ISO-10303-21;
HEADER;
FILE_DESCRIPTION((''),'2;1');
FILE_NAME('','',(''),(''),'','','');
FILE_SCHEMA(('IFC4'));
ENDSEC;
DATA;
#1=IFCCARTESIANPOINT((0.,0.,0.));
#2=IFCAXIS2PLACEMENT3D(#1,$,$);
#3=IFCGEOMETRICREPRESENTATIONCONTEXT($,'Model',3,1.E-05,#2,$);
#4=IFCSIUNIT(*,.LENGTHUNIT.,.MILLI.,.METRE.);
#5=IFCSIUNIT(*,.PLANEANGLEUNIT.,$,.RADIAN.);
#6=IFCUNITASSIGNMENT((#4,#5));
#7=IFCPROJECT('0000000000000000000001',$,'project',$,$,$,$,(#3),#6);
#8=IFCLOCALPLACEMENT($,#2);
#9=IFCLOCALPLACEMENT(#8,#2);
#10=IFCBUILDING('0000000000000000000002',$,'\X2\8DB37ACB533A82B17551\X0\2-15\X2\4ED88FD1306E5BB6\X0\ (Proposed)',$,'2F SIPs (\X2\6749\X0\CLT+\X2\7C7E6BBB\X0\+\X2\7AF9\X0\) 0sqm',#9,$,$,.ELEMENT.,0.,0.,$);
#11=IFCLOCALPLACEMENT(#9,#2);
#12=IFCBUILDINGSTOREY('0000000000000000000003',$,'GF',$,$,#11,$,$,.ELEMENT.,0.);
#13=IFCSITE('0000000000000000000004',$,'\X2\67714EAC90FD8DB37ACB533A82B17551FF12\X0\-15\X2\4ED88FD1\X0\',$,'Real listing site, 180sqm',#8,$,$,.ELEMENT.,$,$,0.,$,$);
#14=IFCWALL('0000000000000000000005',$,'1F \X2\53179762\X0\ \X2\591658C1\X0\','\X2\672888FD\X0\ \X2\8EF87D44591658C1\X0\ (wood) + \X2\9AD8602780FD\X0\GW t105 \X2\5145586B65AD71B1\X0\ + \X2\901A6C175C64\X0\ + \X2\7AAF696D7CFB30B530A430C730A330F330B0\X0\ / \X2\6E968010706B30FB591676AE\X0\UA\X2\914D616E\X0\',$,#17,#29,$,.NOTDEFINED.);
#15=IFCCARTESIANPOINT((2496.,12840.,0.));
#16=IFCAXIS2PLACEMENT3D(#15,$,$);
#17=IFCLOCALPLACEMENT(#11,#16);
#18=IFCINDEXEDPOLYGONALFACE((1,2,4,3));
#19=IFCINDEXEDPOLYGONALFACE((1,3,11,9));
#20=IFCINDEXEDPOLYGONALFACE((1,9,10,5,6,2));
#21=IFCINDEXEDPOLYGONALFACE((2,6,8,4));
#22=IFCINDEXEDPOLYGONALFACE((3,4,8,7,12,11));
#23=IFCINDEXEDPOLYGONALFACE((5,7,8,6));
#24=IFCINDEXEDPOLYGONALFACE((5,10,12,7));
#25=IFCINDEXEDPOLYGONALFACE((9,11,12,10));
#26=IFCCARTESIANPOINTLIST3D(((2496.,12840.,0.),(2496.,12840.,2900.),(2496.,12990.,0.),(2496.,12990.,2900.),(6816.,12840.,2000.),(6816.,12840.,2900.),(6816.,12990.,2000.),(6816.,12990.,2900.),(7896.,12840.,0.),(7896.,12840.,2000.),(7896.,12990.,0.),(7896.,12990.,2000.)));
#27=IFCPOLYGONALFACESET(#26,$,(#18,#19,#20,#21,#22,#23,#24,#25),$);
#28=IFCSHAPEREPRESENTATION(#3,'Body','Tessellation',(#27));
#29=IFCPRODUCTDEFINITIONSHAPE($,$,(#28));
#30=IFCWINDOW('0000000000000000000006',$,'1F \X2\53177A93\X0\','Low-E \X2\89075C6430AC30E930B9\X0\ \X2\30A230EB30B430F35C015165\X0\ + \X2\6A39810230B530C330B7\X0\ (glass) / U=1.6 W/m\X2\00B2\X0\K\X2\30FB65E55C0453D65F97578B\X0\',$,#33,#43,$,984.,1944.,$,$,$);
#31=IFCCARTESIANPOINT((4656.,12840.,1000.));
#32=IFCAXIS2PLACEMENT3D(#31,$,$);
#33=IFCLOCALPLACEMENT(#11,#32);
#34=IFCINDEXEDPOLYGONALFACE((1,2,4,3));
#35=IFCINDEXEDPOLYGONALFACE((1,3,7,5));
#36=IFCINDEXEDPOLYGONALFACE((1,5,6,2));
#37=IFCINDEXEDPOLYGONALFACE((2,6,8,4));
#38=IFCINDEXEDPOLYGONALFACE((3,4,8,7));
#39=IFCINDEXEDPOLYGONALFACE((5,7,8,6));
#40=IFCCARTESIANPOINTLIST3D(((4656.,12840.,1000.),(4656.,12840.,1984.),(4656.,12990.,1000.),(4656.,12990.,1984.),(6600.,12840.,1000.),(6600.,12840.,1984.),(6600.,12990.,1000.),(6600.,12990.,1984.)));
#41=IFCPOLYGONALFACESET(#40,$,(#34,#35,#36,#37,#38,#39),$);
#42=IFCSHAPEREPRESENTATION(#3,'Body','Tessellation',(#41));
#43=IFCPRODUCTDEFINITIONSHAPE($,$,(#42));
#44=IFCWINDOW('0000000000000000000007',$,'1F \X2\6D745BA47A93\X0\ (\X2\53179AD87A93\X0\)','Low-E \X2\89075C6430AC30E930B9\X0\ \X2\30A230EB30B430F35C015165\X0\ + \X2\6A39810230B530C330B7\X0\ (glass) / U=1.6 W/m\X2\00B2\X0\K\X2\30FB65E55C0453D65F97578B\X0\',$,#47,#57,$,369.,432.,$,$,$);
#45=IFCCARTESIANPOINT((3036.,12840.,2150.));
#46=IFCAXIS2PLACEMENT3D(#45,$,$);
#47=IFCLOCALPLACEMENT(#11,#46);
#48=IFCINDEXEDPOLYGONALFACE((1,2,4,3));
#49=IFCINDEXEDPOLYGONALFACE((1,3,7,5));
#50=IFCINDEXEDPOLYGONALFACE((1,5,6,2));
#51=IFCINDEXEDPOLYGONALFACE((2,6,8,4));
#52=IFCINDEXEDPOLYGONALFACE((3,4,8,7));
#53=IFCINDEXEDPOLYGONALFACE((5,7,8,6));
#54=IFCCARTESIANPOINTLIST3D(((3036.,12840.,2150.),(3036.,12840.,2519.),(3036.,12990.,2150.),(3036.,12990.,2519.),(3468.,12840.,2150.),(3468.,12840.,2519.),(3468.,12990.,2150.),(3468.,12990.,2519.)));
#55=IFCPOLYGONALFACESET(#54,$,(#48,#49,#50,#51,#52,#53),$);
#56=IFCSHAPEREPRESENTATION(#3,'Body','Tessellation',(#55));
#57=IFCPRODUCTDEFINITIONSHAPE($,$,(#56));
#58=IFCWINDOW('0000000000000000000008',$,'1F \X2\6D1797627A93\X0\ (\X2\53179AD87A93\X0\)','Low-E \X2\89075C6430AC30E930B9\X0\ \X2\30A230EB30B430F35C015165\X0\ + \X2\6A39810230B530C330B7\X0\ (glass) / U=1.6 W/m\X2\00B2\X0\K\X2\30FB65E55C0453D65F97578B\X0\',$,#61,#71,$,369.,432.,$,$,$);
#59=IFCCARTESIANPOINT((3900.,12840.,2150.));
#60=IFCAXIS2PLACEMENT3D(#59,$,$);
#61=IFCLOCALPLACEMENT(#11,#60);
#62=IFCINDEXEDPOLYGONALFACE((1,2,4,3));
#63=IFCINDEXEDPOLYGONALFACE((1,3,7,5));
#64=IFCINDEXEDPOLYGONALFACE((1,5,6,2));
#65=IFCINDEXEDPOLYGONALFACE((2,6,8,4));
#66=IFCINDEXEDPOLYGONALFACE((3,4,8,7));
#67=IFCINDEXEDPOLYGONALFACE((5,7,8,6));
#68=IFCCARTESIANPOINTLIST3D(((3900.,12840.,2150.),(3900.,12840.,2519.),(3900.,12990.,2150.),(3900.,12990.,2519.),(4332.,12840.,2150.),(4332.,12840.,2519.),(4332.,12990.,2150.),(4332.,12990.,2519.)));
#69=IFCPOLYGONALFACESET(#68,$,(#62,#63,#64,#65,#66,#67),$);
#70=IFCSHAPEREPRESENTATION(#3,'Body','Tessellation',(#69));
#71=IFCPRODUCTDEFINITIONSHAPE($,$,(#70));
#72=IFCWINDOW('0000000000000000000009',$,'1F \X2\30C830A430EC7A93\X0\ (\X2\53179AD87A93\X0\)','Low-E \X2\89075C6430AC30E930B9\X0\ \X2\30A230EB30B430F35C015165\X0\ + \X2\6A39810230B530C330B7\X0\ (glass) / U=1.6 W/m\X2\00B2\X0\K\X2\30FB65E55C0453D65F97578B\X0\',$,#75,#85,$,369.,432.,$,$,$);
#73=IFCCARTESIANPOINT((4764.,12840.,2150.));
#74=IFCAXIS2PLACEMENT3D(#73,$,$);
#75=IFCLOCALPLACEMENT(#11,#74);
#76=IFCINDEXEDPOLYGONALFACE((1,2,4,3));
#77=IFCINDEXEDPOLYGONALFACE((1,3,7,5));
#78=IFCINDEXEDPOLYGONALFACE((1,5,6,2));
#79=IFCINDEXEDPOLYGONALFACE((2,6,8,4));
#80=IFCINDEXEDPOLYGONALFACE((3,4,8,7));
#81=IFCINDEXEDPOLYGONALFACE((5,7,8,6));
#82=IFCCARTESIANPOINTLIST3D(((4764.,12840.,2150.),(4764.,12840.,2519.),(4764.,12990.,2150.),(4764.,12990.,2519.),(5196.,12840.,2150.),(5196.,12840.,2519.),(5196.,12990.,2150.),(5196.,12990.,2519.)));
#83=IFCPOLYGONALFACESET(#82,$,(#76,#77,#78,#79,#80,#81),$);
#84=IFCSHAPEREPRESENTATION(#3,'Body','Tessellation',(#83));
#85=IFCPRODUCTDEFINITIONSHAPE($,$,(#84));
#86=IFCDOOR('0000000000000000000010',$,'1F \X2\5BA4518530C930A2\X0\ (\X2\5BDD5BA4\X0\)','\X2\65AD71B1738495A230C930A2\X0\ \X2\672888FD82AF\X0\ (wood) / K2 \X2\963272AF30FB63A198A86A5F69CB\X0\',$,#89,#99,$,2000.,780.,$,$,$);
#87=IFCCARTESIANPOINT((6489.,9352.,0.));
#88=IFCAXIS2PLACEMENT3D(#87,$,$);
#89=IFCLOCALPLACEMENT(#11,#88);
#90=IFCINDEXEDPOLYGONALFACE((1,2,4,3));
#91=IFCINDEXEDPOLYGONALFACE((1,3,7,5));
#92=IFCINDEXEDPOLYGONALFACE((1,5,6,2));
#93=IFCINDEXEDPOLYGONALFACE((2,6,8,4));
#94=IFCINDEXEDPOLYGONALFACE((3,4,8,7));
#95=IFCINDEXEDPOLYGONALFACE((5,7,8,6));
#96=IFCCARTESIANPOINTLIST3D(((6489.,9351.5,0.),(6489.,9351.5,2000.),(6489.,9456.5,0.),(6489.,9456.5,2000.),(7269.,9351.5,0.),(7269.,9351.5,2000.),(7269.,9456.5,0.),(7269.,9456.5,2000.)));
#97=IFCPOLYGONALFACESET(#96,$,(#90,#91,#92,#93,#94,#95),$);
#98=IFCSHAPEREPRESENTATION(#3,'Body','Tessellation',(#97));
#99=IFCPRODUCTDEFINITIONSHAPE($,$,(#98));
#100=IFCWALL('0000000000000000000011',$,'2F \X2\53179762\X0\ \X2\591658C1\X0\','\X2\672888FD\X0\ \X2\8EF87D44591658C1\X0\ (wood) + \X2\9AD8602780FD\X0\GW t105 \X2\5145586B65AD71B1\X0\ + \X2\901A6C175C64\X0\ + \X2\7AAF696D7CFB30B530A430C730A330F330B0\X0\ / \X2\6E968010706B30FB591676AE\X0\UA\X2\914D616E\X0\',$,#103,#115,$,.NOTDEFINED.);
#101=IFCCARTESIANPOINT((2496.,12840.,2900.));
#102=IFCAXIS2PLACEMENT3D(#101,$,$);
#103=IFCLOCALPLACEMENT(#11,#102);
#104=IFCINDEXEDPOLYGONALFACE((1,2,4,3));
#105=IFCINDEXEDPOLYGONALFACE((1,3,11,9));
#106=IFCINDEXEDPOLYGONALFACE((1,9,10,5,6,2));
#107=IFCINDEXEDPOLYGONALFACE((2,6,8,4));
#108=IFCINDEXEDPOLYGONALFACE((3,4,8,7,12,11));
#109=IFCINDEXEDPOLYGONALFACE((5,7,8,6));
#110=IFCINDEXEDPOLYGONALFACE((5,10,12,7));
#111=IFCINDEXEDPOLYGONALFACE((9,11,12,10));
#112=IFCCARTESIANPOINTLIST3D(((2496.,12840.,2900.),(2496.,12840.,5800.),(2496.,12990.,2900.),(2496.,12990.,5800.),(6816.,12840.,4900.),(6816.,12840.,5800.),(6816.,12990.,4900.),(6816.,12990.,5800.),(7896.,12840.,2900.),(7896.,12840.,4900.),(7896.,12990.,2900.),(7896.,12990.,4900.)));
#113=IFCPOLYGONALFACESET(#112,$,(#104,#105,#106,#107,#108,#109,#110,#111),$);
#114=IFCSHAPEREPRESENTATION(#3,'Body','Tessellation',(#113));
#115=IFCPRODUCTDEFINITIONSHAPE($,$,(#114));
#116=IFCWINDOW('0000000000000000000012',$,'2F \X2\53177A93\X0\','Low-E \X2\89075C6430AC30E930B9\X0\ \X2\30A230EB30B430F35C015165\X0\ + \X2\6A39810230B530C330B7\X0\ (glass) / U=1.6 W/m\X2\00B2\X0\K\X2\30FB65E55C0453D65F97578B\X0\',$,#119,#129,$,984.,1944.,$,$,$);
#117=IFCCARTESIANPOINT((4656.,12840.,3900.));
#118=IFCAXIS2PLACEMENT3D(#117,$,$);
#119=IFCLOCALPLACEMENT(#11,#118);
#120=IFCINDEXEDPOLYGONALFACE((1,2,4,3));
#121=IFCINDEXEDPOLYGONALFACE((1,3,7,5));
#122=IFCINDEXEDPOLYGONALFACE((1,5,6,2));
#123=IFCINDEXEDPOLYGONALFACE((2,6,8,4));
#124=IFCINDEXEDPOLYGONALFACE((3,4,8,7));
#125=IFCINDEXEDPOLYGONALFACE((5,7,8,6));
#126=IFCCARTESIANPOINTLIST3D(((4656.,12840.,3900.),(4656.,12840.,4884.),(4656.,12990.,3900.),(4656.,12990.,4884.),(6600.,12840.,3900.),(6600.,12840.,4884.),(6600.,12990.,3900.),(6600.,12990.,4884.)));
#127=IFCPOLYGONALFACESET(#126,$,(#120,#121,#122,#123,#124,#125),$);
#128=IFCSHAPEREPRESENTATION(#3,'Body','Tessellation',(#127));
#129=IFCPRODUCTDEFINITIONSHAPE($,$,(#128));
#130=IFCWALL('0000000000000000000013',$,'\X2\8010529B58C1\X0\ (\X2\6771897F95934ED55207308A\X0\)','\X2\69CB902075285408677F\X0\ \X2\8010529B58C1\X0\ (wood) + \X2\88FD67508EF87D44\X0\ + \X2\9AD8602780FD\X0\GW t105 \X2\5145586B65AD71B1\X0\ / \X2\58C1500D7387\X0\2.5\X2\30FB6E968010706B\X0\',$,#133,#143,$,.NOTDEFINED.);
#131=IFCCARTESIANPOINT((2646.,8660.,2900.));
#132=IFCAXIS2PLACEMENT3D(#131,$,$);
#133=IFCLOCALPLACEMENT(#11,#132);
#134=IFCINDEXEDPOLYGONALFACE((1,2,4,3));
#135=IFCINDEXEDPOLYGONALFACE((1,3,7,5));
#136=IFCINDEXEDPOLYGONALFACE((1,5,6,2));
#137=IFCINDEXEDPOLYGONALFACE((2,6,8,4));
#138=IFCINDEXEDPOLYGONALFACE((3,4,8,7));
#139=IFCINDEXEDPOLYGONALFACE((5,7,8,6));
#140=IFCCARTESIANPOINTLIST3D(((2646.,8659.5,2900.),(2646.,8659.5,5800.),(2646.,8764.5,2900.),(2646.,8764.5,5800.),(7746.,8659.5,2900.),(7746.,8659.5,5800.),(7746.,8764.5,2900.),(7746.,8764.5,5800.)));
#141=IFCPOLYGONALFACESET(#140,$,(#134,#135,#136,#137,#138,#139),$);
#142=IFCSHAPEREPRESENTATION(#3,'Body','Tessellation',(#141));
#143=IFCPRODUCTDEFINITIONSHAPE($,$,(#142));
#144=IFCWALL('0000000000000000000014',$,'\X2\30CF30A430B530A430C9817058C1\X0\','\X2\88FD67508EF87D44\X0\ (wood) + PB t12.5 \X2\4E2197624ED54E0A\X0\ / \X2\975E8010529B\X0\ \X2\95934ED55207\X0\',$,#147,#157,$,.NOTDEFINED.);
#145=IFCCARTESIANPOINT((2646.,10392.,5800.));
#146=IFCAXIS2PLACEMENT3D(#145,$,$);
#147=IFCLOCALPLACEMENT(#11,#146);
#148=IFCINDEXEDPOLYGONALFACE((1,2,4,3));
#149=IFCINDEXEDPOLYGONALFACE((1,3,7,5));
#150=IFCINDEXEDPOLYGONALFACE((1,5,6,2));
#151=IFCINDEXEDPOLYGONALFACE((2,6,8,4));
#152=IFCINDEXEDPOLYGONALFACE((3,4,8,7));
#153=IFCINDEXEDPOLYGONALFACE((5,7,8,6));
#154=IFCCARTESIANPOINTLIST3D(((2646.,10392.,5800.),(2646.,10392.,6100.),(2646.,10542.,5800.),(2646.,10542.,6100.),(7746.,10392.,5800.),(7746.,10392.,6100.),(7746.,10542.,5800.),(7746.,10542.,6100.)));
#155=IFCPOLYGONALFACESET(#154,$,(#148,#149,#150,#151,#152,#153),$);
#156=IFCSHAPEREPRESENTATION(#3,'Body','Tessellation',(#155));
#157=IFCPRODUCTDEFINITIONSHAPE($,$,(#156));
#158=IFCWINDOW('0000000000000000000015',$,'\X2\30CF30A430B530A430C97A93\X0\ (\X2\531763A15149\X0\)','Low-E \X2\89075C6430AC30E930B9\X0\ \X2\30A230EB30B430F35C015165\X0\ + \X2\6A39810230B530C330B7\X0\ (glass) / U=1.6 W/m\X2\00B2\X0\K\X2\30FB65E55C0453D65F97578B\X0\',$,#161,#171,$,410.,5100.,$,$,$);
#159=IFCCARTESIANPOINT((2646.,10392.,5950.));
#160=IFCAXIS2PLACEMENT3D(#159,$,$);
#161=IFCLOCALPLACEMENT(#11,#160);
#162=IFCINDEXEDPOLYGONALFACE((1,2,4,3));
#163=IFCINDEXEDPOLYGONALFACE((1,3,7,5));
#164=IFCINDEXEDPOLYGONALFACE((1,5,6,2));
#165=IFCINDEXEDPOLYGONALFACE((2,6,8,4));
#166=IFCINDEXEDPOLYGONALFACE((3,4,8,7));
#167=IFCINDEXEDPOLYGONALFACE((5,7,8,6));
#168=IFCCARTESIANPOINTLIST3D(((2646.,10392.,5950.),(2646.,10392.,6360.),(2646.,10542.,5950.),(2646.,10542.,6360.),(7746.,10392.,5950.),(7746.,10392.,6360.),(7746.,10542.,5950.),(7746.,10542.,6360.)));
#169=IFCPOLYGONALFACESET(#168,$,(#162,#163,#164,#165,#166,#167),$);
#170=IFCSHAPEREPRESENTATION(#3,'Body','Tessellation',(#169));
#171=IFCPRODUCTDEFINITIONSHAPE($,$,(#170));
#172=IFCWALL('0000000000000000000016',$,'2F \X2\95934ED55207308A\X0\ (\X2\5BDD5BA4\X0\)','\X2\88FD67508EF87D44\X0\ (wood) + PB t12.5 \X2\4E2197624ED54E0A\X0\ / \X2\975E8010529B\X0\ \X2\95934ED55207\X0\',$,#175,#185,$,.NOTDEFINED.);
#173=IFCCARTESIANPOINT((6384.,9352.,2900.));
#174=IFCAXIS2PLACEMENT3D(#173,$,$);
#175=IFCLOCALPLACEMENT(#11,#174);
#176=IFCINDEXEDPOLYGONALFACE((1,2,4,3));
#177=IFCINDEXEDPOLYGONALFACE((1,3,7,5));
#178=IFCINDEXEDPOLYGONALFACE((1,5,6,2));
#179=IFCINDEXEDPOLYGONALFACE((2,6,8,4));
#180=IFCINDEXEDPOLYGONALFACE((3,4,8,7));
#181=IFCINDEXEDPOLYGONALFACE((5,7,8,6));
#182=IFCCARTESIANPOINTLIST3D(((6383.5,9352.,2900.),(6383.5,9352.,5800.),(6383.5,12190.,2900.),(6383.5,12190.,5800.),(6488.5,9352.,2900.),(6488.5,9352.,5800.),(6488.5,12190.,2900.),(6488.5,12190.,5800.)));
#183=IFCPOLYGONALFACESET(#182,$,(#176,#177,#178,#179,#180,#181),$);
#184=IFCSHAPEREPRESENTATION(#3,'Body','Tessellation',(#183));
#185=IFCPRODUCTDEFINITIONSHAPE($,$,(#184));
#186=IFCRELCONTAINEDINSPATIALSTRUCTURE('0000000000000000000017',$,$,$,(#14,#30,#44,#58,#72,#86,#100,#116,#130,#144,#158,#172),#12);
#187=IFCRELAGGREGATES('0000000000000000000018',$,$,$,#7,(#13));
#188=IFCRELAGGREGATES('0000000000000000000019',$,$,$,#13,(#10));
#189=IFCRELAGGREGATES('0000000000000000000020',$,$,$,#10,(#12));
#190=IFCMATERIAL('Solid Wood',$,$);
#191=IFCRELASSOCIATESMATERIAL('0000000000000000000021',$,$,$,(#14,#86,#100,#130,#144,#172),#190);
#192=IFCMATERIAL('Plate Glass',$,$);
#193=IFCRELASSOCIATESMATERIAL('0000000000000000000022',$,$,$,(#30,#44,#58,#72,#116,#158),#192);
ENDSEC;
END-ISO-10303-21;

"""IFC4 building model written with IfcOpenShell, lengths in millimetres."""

from ifc_helpers import new_model, si_unit, frame, frame_2d, origin, place, context, project, spatial, rectangle, extrude, material, element, fill, save


model = new_model("IFC4")

# Units and contexts
model_context = context("Model", 3, precision=1e-05, world=origin())
ifc_project = project(units=[si_unit("LENGTHUNIT", "METRE", prefix="MILLI"), si_unit("PLANEANGLEUNIT", "RADIAN")], contexts=[model_context])

# Site, building, storey
site_placement = place(None, origin())
site = spatial("IfcSite", under=ifc_project, at=site_placement, Name="東京都足立区花畑２-15付近", ObjectType="Real listing site, 180sqm", CompositionType="ELEMENT", RefElevation=0.0)
building_placement = place(site_placement, origin())
building = spatial("IfcBuilding", under=site, at=building_placement, Name="足立区花畑2-15付近の家 (Proposed)", ObjectType="2F SIPs (杉CLT+籾殻+竹) 0sqm", CompositionType="ELEMENT", ElevationOfRefHeight=0.0, ElevationOfTerrain=0.0)
storey_placement = place(building_placement, origin())
storey = spatial("IfcBuildingStorey", under=building, at=storey_placement, Name="GF", CompositionType="ELEMENT", Elevation=0.0)

# Wall, openings, windows
ifc_material_1 = material(Name="Solid Wood")
wall_1_placement = place(storey_placement, frame((2496.0, 12840.0, 0.0)))
wall_1 = element("IfcWall", 1, at=wall_1_placement, inside=storey, material=ifc_material_1, Name="1F 北面 外壁", Description="木製 軸組外壁 (wood) + 高性能GW t105 充填断熱 + 通気層 + 窯業系サイディング / 準耐火・外皮UA配慮", PredefinedType="NOTDEFINED", context=model_context, shape_type="SweptSolid", body=[
    extrude(rectangle(XDim=5400.0, YDim=150.0, at=frame_2d((2700.0, 75.0))), frame((2496.0, 12840.0, 0.0)), (0.0, 0.0, 1.0), 2900.0),
])
opening_1_placement = place(storey_placement, frame((4656.0, 12840.0, 1000.0)))
opening_1 = element("IfcOpeningElement", 2, at=opening_1_placement, cuts=wall_1, PredefinedType="NOTDEFINED", context=model_context, shape_type="SweptSolid", body=[
    extrude(rectangle(XDim=1944.0, YDim=150.0, at=frame_2d((972.0, 75.0))), frame((4656.0, 12840.0, 1000.0)), (0.0, 0.0, 1.0), 984.0),
])
opening_2_placement = place(storey_placement, frame((3036.0, 12840.0, 2150.0)))
opening_2 = element("IfcOpeningElement", 3, at=opening_2_placement, cuts=wall_1, PredefinedType="NOTDEFINED", context=model_context, shape_type="SweptSolid", body=[
    extrude(rectangle(XDim=432.0, YDim=150.0, at=frame_2d((216.0, 75.0))), frame((3036.0, 12840.0, 2150.0)), (0.0, 0.0, 1.0), 369.0),
])
opening_3_placement = place(storey_placement, frame((3900.0, 12840.0, 2150.0)))
opening_3 = element("IfcOpeningElement", 4, at=opening_3_placement, cuts=wall_1, PredefinedType="NOTDEFINED", context=model_context, shape_type="SweptSolid", body=[
    extrude(rectangle(XDim=432.0, YDim=150.0, at=frame_2d((216.0, 75.0))), frame((3900.0, 12840.0, 2150.0)), (0.0, 0.0, 1.0), 369.0),
])
opening_4_placement = place(storey_placement, frame((4764.0, 12840.0, 2150.0)))
opening_4 = element("IfcOpeningElement", 5, at=opening_4_placement, cuts=wall_1, PredefinedType="NOTDEFINED", context=model_context, shape_type="SweptSolid", body=[
    extrude(rectangle(XDim=432.0, YDim=150.0, at=frame_2d((216.0, 75.0))), frame((4764.0, 12840.0, 2150.0)), (0.0, 0.0, 1.0), 369.0),
])
ifc_material_2 = material(Name="Plate Glass")
window_1_placement = place(storey_placement, frame((4656.0, 12840.0, 1000.0)))
window_1 = element("IfcWindow", 6, at=window_1_placement, inside=storey, material=ifc_material_2, Name="1F 北窓", Description="Low-E 複層ガラス アルゴン封入 + 樹脂サッシ (glass) / U=1.6 W/m²K・日射取得型", OverallHeight=984.0, OverallWidth=1944.0, context=model_context, shape_type="SweptSolid", body=[
    extrude(rectangle(XDim=1944.0, YDim=150.0, at=frame_2d((972.0, 75.0))), frame((4656.0, 12840.0, 1000.0)), (0.0, 0.0, 1.0), 984.0),
])
fill(opening_1, window_1)
window_2_placement = place(storey_placement, frame((3036.0, 12840.0, 2150.0)))
window_2 = element("IfcWindow", 7, at=window_2_placement, inside=storey, material=ifc_material_2, Name="1F 浴室窓 (北高窓)", Description="Low-E 複層ガラス アルゴン封入 + 樹脂サッシ (glass) / U=1.6 W/m²K・日射取得型", OverallHeight=369.0, OverallWidth=432.0, context=model_context, shape_type="SweptSolid", body=[
    extrude(rectangle(XDim=432.0, YDim=150.0, at=frame_2d((216.0, 75.0))), frame((3036.0, 12840.0, 2150.0)), (0.0, 0.0, 1.0), 369.0),
])
fill(opening_2, window_2)
window_3_placement = place(storey_placement, frame((3900.0, 12840.0, 2150.0)))
window_3 = element("IfcWindow", 8, at=window_3_placement, inside=storey, material=ifc_material_2, Name="1F 洗面窓 (北高窓)", Description="Low-E 複層ガラス アルゴン封入 + 樹脂サッシ (glass) / U=1.6 W/m²K・日射取得型", OverallHeight=369.0, OverallWidth=432.0, context=model_context, shape_type="SweptSolid", body=[
    extrude(rectangle(XDim=432.0, YDim=150.0, at=frame_2d((216.0, 75.0))), frame((3900.0, 12840.0, 2150.0)), (0.0, 0.0, 1.0), 369.0),
])
fill(opening_3, window_3)
window_4_placement = place(storey_placement, frame((4764.0, 12840.0, 2150.0)))
window_4 = element("IfcWindow", 9, at=window_4_placement, inside=storey, material=ifc_material_2, Name="1F トイレ窓 (北高窓)", Description="Low-E 複層ガラス アルゴン封入 + 樹脂サッシ (glass) / U=1.6 W/m²K・日射取得型", OverallHeight=369.0, OverallWidth=432.0, context=model_context, shape_type="SweptSolid", body=[
    extrude(rectangle(XDim=432.0, YDim=150.0, at=frame_2d((216.0, 75.0))), frame((4764.0, 12840.0, 2150.0)), (0.0, 0.0, 1.0), 369.0),
])
fill(opening_4, window_4)

# Door
door_1_placement = place(storey_placement, frame((6489.0, 9352.0, 0.0)))
element("IfcDoor", 10, at=door_1_placement, inside=storey, material=ifc_material_1, Name="1F 室内ドア (寝室)", Description="断熱玄関ドア 木製芯 (wood) / K2 防犯・採風機構", OverallHeight=2000.0, OverallWidth=780.0, context=model_context, shape_type="SweptSolid", body=[
    extrude(rectangle(XDim=780.0, YDim=105.0, at=frame_2d((390.0, 52.0))), frame((6489.0, 9352.0, 0.0)), (0.0, 0.0, 1.0), 2000.0),
])

# Wall, opening, window
wall_2_placement = place(storey_placement, frame((2496.0, 12840.0, 2900.0)))
wall_2 = element("IfcWall", 11, at=wall_2_placement, inside=storey, material=ifc_material_1, Name="2F 北面 外壁", Description="木製 軸組外壁 (wood) + 高性能GW t105 充填断熱 + 通気層 + 窯業系サイディング / 準耐火・外皮UA配慮", PredefinedType="NOTDEFINED", context=model_context, shape_type="SweptSolid", body=[
    extrude(rectangle(XDim=5400.0, YDim=150.0, at=frame_2d((2700.0, 75.0))), frame((2496.0, 12840.0, 2900.0)), (0.0, 0.0, 1.0), 2900.0),
])
opening_5_placement = place(storey_placement, frame((4656.0, 12840.0, 3900.0)))
opening_5 = element("IfcOpeningElement", 12, at=opening_5_placement, cuts=wall_2, PredefinedType="NOTDEFINED", context=model_context, shape_type="SweptSolid", body=[
    extrude(rectangle(XDim=1944.0, YDim=150.0, at=frame_2d((972.0, 75.0))), frame((4656.0, 12840.0, 3900.0)), (0.0, 0.0, 1.0), 984.0),
])
window_5_placement = place(storey_placement, frame((4656.0, 12840.0, 3900.0)))
window_5 = element("IfcWindow", 13, at=window_5_placement, inside=storey, material=ifc_material_2, Name="2F 北窓", Description="Low-E 複層ガラス アルゴン封入 + 樹脂サッシ (glass) / U=1.6 W/m²K・日射取得型", OverallHeight=984.0, OverallWidth=1944.0, context=model_context, shape_type="SweptSolid", body=[
    extrude(rectangle(XDim=1944.0, YDim=150.0, at=frame_2d((972.0, 75.0))), frame((4656.0, 12840.0, 3900.0)), (0.0, 0.0, 1.0), 984.0),
])
fill(opening_5, window_5)

# Wall
wall_3_placement = place(storey_placement, frame((2646.0, 8660.0, 2900.0)))
element("IfcWall", 14, at=wall_3_placement, inside=storey, material=ifc_material_1, Name="耐力壁 (東西間仕切り)", Description="構造用合板 耐力壁 (wood) + 製材軸組 + 高性能GW t105 充填断熱 / 壁倍率2.5・準耐火", PredefinedType="NOTDEFINED", context=model_context, shape_type="SweptSolid", body=[
    extrude(rectangle(XDim=5100.0, YDim=105.0, at=frame_2d((2550.0, 52.0))), frame((2646.0, 8660.0, 2900.0)), (0.0, 0.0, 1.0), 2900.0),
])

# Wall, opening, window
wall_4_placement = place(storey_placement, frame((2646.0, 10392.0, 5800.0)))
wall_4 = element("IfcWall", 15, at=wall_4_placement, inside=storey, material=ifc_material_1, Name="ハイサイド腰壁", Description="製材軸組 (wood) + PB t12.5 両面仕上 / 非耐力 間仕切", PredefinedType="NOTDEFINED", context=model_context, shape_type="SweptSolid", body=[
    extrude(rectangle(XDim=5100.0, YDim=150.0, at=frame_2d((2550.0, 75.0))), frame((2646.0, 10392.0, 5800.0)), (0.0, 0.0, 1.0), 700.0),
])
opening_6_placement = place(storey_placement, frame((2646.0, 10392.0, 5950.0)))
opening_6 = element("IfcOpeningElement", 16, at=opening_6_placement, cuts=wall_4, PredefinedType="NOTDEFINED", context=model_context, shape_type="SweptSolid", body=[
    extrude(rectangle(XDim=5100.0, YDim=150.0, at=frame_2d((2550.0, 75.0))), frame((2646.0, 10392.0, 5950.0)), (0.0, 0.0, 1.0), 410.0),
])
window_6_placement = place(storey_placement, frame((2646.0, 10392.0, 5950.0)))
window_6 = element("IfcWindow", 17, at=window_6_placement, inside=storey, material=ifc_material_2, Name="ハイサイド窓 (北採光)", Description="Low-E 複層ガラス アルゴン封入 + 樹脂サッシ (glass) / U=1.6 W/m²K・日射取得型", OverallHeight=410.0, OverallWidth=5100.0, context=model_context, shape_type="SweptSolid", body=[
    extrude(rectangle(XDim=5100.0, YDim=150.0, at=frame_2d((2550.0, 75.0))), frame((2646.0, 10392.0, 5950.0)), (0.0, 0.0, 1.0), 410.0),
])
fill(opening_6, window_6)

# Wall
wall_5_placement = place(storey_placement, frame((6384.0, 9352.0, 2900.0)))
element("IfcWall", 18, at=wall_5_placement, inside=storey, material=ifc_material_1, Name="2F 間仕切り (寝室)", Description="製材軸組 (wood) + PB t12.5 両面仕上 / 非耐力 間仕切", PredefinedType="NOTDEFINED", context=model_context, shape_type="SweptSolid", body=[
    extrude(rectangle(XDim=105.0, YDim=2838.0, at=frame_2d((52.0, 1419.0))), frame((6384.0, 9352.0, 2900.0)), (0.0, 0.0, 1.0), 2900.0),
])

save(model, "model.ifc")
